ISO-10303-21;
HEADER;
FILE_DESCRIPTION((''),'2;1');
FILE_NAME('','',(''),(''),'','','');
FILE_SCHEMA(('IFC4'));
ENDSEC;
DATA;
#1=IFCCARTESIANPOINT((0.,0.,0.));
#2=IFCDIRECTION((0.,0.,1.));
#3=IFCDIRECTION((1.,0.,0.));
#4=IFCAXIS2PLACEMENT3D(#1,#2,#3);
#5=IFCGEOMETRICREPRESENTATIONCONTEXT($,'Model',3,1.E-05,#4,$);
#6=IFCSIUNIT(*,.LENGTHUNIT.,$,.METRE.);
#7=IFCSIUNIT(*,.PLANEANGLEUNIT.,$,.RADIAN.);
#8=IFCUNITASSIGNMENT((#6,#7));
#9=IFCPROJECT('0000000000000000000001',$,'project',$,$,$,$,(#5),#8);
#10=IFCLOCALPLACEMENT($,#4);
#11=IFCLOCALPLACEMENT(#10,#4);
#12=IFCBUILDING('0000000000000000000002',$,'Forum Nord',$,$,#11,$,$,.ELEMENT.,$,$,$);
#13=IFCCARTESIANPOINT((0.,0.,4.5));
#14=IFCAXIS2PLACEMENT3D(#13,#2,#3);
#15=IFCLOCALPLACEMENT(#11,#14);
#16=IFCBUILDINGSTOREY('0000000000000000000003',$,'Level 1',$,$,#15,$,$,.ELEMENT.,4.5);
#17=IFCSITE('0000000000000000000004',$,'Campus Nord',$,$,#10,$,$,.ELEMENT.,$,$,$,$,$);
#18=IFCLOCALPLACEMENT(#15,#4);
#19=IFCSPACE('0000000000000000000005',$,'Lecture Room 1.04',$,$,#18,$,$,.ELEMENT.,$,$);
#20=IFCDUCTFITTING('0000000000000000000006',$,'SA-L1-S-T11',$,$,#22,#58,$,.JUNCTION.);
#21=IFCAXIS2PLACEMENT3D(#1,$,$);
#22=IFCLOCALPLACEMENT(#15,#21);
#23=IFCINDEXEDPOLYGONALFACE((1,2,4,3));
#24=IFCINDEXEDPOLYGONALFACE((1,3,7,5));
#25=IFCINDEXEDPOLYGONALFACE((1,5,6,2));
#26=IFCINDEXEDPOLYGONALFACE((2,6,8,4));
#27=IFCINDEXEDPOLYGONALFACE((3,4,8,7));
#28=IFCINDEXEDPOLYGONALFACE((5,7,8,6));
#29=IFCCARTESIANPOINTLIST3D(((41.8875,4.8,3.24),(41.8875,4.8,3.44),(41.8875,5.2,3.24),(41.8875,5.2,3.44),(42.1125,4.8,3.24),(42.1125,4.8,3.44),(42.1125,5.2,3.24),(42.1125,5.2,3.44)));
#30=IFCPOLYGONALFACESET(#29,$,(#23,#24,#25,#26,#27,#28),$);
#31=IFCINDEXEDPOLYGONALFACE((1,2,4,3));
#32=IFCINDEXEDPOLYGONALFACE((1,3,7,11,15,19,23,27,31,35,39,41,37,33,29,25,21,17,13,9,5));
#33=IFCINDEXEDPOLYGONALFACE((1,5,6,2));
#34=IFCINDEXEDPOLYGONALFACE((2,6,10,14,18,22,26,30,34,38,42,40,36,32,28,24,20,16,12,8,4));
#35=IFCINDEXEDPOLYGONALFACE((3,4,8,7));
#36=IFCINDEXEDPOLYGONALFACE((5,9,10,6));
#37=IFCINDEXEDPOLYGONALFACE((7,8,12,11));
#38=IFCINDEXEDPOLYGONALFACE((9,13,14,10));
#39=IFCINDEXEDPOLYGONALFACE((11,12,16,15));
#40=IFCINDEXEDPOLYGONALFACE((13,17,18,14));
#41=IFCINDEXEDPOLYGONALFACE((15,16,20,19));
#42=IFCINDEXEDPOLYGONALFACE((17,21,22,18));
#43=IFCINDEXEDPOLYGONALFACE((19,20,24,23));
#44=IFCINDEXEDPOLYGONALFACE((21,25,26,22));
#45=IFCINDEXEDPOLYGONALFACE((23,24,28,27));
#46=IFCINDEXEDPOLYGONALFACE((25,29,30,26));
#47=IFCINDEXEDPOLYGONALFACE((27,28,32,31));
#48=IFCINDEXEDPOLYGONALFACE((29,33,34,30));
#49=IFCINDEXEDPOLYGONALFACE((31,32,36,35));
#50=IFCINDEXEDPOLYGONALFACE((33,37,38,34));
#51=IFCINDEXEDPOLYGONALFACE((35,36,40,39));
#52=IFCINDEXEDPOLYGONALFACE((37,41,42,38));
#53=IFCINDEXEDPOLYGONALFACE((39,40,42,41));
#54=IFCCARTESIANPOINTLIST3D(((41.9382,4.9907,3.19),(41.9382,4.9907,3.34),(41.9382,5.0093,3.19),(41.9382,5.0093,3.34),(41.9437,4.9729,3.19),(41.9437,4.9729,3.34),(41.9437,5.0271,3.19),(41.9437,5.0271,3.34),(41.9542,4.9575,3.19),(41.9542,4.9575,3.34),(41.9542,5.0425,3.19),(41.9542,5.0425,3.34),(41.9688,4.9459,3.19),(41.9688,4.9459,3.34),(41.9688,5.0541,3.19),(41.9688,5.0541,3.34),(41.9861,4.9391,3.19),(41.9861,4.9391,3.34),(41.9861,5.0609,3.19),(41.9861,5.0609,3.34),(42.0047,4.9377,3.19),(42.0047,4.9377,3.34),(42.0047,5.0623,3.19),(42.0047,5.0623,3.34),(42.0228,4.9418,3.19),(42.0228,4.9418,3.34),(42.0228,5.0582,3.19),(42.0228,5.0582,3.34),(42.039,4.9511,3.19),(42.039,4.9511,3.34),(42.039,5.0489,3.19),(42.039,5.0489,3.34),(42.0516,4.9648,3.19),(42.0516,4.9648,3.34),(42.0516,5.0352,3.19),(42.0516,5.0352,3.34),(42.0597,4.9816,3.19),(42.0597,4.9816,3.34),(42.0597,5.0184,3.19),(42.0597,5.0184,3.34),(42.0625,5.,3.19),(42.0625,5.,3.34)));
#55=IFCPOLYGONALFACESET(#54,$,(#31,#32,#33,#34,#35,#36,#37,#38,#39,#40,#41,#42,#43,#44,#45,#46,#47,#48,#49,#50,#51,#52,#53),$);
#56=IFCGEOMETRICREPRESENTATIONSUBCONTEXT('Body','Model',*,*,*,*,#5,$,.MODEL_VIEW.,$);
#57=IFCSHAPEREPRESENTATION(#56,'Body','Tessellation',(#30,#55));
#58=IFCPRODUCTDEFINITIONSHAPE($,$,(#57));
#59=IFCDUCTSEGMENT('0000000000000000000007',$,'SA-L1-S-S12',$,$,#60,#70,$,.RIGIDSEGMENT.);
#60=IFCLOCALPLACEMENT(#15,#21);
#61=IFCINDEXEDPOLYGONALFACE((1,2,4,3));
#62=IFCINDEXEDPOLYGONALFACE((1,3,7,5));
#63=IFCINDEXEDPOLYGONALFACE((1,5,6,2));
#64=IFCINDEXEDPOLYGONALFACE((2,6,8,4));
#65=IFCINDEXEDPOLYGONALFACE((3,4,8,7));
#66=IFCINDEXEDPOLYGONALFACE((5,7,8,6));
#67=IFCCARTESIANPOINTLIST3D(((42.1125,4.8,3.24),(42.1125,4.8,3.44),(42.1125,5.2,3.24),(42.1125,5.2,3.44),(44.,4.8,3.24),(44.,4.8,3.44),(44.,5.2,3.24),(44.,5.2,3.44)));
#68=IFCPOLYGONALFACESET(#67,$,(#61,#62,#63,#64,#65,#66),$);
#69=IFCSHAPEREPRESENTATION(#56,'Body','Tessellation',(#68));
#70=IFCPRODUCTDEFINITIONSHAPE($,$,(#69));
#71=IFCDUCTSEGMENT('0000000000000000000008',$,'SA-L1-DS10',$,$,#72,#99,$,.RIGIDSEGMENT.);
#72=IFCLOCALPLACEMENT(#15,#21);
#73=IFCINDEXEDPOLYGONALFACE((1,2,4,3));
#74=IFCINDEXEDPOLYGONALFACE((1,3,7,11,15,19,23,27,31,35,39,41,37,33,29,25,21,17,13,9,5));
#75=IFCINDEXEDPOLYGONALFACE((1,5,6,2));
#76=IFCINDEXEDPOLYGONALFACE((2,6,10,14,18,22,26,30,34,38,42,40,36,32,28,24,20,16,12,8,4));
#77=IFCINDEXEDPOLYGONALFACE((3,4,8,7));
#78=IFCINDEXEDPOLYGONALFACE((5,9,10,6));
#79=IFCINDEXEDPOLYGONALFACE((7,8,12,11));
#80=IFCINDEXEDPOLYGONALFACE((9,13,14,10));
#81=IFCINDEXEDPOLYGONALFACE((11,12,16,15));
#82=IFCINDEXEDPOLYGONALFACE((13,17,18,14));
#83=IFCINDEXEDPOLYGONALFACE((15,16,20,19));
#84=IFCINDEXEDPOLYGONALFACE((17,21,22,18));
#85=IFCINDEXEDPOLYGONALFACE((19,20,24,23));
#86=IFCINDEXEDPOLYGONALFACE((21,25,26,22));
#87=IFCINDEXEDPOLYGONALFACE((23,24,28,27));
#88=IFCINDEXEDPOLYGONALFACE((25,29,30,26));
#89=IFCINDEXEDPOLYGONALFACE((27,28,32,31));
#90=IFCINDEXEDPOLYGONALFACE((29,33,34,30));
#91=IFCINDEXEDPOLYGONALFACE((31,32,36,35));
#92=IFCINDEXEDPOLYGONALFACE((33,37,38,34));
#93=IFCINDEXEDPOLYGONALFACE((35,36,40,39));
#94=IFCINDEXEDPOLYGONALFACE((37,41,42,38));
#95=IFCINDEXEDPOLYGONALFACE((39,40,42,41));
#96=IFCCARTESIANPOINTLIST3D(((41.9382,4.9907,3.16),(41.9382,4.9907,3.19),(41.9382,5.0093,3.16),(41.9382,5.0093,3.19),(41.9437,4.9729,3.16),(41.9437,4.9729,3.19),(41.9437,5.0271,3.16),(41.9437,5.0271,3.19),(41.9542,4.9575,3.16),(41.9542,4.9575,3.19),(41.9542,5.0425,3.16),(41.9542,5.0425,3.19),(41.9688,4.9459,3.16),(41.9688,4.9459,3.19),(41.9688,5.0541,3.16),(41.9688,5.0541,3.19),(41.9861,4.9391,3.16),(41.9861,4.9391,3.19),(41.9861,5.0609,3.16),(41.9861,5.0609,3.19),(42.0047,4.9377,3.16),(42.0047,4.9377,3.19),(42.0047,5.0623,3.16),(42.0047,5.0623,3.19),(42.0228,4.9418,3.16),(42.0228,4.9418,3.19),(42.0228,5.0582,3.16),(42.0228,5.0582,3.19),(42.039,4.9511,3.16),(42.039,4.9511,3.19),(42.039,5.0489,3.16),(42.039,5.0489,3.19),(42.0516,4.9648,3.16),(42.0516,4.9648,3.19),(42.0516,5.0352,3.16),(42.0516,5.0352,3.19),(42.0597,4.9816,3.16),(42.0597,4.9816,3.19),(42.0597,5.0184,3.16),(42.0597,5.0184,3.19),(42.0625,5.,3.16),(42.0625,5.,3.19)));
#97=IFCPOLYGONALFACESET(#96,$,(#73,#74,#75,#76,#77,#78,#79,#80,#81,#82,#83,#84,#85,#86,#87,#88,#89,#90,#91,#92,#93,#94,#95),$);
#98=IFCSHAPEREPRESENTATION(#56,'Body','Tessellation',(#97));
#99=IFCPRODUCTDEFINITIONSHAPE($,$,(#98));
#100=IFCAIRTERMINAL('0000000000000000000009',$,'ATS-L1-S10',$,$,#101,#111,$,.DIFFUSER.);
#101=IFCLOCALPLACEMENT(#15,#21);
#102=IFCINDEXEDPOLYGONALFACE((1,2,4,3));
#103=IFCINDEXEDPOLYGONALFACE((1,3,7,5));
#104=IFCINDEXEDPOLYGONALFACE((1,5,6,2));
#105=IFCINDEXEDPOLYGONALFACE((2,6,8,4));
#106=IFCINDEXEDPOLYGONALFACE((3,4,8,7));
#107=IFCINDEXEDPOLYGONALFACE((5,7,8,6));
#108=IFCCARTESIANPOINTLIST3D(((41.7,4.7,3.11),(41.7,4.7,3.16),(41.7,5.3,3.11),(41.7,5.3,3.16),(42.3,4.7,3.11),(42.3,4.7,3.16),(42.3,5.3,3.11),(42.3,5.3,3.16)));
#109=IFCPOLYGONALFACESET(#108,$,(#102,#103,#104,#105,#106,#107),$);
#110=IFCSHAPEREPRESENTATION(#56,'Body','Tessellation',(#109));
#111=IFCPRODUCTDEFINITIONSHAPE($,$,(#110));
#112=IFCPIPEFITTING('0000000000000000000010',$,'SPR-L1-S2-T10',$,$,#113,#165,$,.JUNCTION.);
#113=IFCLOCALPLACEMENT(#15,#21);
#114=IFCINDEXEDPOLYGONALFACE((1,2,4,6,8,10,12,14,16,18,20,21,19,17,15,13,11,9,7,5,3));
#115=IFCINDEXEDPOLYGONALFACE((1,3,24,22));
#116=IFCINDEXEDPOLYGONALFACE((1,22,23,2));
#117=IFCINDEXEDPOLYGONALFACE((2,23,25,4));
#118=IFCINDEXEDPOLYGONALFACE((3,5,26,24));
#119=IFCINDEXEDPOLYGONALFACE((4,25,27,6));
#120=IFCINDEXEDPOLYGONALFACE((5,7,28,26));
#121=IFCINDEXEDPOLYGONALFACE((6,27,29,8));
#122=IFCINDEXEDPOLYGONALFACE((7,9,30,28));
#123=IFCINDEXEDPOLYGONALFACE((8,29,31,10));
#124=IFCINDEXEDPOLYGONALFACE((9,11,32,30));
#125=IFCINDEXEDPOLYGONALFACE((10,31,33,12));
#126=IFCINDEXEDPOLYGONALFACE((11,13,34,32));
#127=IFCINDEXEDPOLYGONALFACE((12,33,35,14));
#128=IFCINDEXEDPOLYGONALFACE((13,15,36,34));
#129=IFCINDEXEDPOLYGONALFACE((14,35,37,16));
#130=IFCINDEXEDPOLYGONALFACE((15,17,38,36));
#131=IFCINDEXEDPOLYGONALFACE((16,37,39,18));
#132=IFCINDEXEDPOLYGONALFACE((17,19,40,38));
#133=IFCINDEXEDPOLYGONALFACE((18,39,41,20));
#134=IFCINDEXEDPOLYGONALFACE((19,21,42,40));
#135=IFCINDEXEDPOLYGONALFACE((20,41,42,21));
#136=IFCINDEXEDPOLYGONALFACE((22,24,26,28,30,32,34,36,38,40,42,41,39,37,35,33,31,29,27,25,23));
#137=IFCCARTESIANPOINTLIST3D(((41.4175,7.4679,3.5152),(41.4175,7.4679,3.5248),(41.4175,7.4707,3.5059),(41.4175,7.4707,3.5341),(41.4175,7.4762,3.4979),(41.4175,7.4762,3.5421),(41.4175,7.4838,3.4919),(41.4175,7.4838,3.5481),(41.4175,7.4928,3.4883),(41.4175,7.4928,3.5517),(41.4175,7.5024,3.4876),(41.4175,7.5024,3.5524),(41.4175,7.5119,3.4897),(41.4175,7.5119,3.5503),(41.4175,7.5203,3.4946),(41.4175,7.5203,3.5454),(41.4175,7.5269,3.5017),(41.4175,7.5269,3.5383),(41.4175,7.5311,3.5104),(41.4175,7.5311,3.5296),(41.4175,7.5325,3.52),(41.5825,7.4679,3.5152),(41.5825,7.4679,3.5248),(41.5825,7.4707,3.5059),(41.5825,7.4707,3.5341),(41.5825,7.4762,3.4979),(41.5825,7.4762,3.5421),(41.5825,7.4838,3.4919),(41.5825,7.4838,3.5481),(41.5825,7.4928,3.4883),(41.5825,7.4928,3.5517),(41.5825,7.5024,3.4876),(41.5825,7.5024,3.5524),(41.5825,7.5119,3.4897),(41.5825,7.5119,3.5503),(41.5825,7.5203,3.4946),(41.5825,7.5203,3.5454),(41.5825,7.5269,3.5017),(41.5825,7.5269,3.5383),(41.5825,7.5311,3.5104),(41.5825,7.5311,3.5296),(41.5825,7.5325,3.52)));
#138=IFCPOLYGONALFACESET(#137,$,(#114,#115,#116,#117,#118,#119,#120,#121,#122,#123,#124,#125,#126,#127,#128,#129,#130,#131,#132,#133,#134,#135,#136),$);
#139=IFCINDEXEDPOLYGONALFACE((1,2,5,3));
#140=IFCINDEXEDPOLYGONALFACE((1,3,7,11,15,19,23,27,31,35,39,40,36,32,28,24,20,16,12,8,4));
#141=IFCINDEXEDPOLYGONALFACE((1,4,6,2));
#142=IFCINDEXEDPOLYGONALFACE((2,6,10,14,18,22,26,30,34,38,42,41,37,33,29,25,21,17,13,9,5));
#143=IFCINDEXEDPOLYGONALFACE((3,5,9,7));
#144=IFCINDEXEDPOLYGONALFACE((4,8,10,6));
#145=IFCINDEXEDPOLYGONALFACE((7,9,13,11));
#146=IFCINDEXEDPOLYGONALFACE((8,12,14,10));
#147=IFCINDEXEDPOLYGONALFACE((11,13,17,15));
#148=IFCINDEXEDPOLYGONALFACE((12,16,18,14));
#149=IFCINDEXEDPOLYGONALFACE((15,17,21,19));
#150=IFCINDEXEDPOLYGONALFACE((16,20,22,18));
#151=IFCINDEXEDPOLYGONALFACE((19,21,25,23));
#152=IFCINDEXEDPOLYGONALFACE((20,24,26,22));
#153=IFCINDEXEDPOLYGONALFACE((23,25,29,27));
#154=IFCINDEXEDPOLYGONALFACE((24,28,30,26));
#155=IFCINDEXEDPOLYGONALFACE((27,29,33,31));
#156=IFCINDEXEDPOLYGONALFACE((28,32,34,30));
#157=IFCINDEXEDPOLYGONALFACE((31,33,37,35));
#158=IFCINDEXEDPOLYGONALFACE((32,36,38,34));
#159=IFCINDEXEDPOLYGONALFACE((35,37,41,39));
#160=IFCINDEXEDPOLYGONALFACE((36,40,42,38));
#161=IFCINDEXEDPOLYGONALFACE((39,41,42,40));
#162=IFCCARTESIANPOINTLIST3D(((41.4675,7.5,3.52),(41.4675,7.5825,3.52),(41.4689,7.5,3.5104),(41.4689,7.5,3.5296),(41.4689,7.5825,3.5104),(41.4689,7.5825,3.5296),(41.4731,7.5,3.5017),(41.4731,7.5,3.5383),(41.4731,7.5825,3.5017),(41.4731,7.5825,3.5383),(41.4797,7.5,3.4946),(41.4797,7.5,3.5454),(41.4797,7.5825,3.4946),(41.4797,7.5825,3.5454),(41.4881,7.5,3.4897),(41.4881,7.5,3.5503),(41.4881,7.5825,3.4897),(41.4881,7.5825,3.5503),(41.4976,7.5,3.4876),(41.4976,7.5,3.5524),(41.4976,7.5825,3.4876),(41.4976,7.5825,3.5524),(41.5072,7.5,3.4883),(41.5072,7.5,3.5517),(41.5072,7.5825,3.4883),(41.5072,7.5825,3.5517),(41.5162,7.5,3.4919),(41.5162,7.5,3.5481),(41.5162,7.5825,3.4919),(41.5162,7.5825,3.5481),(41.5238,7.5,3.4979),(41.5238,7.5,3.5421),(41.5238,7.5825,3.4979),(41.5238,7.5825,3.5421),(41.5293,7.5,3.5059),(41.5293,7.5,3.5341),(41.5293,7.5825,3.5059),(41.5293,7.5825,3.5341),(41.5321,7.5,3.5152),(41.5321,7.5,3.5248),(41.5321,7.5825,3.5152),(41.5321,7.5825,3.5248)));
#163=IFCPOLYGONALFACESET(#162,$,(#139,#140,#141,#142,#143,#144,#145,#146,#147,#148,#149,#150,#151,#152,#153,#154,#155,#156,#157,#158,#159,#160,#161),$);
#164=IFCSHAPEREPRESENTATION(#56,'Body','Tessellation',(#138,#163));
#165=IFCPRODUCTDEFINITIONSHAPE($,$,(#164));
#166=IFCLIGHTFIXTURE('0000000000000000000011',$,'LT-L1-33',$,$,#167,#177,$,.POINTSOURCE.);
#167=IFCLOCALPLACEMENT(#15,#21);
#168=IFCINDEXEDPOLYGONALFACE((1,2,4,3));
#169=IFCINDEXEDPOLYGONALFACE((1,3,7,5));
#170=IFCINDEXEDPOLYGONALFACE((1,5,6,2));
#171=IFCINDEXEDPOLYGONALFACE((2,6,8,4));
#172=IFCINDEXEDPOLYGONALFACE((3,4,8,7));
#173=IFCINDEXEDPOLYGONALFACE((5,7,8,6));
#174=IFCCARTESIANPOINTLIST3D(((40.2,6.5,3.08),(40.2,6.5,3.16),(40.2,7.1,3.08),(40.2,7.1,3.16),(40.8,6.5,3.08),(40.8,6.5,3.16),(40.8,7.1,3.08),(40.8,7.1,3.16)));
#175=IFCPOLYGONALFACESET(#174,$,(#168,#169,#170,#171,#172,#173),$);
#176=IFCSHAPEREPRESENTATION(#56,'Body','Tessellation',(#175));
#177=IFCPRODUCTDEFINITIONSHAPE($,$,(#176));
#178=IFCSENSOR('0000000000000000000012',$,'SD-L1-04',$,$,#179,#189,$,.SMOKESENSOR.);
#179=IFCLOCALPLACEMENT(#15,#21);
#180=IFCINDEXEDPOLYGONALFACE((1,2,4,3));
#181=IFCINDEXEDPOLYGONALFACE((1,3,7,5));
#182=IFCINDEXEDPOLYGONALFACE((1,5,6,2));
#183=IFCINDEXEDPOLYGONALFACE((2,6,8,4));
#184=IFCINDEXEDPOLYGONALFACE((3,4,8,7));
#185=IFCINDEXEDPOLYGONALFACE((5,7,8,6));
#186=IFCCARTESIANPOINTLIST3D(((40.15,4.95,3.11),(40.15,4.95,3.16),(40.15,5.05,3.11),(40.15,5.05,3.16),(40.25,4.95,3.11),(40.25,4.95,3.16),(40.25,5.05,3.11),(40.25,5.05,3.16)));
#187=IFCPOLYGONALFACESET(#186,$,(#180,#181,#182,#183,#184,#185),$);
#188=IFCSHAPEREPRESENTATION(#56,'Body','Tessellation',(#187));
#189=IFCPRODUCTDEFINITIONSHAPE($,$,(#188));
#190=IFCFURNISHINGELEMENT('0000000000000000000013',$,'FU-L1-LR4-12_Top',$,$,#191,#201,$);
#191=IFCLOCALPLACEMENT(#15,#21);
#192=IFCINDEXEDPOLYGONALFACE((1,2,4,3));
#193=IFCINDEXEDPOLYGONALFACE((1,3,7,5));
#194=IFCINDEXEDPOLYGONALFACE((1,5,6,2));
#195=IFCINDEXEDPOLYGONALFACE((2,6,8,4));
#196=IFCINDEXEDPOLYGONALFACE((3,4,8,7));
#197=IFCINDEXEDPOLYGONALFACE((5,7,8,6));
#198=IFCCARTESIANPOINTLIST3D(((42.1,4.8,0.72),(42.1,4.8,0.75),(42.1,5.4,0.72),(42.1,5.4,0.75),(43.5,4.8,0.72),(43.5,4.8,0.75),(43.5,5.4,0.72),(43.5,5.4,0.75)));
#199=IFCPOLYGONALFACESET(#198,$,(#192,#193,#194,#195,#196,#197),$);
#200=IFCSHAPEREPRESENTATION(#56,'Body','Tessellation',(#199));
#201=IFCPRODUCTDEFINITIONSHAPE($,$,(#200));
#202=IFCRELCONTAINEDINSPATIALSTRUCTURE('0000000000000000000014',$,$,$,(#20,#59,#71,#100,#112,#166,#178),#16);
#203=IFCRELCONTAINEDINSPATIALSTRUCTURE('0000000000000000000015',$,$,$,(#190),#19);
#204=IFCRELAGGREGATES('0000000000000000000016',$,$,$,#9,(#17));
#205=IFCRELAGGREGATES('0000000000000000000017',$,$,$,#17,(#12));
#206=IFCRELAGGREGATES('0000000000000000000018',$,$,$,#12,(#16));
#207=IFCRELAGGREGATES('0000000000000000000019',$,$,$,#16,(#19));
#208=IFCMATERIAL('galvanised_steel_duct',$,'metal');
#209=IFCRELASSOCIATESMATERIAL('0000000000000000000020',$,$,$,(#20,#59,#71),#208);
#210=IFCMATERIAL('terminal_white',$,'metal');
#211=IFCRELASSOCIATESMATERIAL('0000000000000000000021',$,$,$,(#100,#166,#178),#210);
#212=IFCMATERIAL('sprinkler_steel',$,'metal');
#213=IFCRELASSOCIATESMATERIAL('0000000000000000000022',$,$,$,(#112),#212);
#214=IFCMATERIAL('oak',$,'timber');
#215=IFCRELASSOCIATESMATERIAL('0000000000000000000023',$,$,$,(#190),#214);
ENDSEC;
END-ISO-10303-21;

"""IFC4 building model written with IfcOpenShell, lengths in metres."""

from ifc_helpers import new_model, si_unit, frame, frame_2d, origin_with_axes, origin_2d_with_axis, place, context, subcontext, project, spatial, rectangle, circle, extrude, material, element, save


model = new_model("IFC4")

# Units and contexts
model_context = context("Model", 3, precision=1e-05, world=origin_with_axes())
body_context = subcontext(model_context, "Body", "Model", "MODEL_VIEW")
ifc_project = project(units=[si_unit("LENGTHUNIT", "METRE"), si_unit("PLANEANGLEUNIT", "RADIAN")], contexts=[model_context])

# Site, building, storey
site_placement = place(None, origin_with_axes())
site = spatial("IfcSite", under=ifc_project, at=site_placement, Name="Campus Nord", CompositionType="ELEMENT")
building_placement = place(site_placement, origin_with_axes())
building = spatial("IfcBuilding", under=site, at=building_placement, Name="Forum Nord", CompositionType="ELEMENT")
storey_placement = place(building_placement, frame((0.0, 0.0, 4.5), z_axis=(0.0, 0.0, 1.0), x_axis=(1.0, 0.0, 0.0)))
storey = spatial("IfcBuildingStorey", under=building, at=storey_placement, Name="Level 1", CompositionType="ELEMENT", Elevation=4.5)

# Duct fitting
ifc_material_1 = material(Name="galvanised_steel_duct", Category="metal")
duct_fitting_placement = place(storey_placement, frame((41.8875, 5.0, 3.34), z_axis=(1.0, 0.0, 0.0), x_axis=(0.0, 1.0, 0.0)))
element("IfcDuctFitting", 1, at=duct_fitting_placement, inside=storey, material=ifc_material_1, Name="SA-L1-S-T11", PredefinedType="JUNCTION", context=body_context, shape_type="SweptSolid", body=[
    extrude(rectangle(XDim=0.4, YDim=0.2, at=origin_2d_with_axis()), origin_with_axes(), (0.0, 0.0, 1.0), 0.225),
    extrude(circle(Radius=0.0625, at=origin_2d_with_axis()), frame((0.0, 0.0, 0.1125), z_axis=(0.0, -1.0, 0.0), x_axis=(0.0, 0.0, 1.0)), (0.0, 0.0, 1.0), 0.15),
])

# Duct segments
duct_segment_1_placement = place(storey_placement, frame((42.1125, 5.0, 3.34), z_axis=(1.0, 0.0, 0.0), x_axis=(0.0, 1.0, 0.0)))
element("IfcDuctSegment", 2, at=duct_segment_1_placement, inside=storey, material=ifc_material_1, Name="SA-L1-S-S12", PredefinedType="RIGIDSEGMENT", context=body_context, shape_type="SweptSolid", body=[
    extrude(rectangle(XDim=0.4, YDim=0.2, at=origin_2d_with_axis()), origin_with_axes(), (0.0, 0.0, 1.0), 1.8875),
])
duct_segment_2_placement = place(storey_placement, frame((42.0, 5.0, 3.19), z_axis=(0.0, 0.0, -1.0), x_axis=(1.0, 0.0, 0.0)))
element("IfcDuctSegment", 3, at=duct_segment_2_placement, inside=storey, material=ifc_material_1, Name="SA-L1-DS10", PredefinedType="RIGIDSEGMENT", context=body_context, shape_type="SweptSolid", body=[
    extrude(circle(Radius=0.0625, at=origin_2d_with_axis()), origin_with_axes(), (0.0, 0.0, 1.0), 0.03),
])

# Air terminal
ifc_material_2 = material(Name="terminal_white", Category="metal")
air_terminal_placement = place(storey_placement, frame((42.0, 5.0, 3.11), z_axis=(0.0, 0.0, 1.0), x_axis=(1.0, 0.0, 0.0)))
element("IfcAirTerminal", 4, at=air_terminal_placement, inside=storey, material=ifc_material_2, Name="ATS-L1-S10", PredefinedType="DIFFUSER", context=body_context, shape_type="SweptSolid", body=[
    extrude(rectangle(XDim=0.6, YDim=0.6, at=origin_2d_with_axis()), origin_with_axes(), (0.0, 0.0, 1.0), 0.05),
])

# Pipe fitting
ifc_material_3 = material(Name="sprinkler_steel", Category="metal")
pipe_fitting_placement = place(storey_placement, frame((41.4175, 7.5, 3.52), z_axis=(1.0, 0.0, 0.0), x_axis=(0.0, 1.0, 0.0)))
element("IfcPipeFitting", 5, at=pipe_fitting_placement, inside=storey, material=ifc_material_3, Name="SPR-L1-S2-T10", PredefinedType="JUNCTION", context=body_context, shape_type="SweptSolid", body=[
    extrude(circle(Radius=0.0325, at=origin_2d_with_axis()), origin_with_axes(), (0.0, 0.0, 1.0), 0.165),
    extrude(circle(Radius=0.0325, at=origin_2d_with_axis()), frame((0.0, 0.0, 0.0825), z_axis=(1.0, 0.0, 0.0), x_axis=(0.0, 0.0, -1.0)), (0.0, 0.0, 1.0), 0.0825),
])

# Light fixture
light_fixture_placement = place(storey_placement, frame((40.5, 6.8, 3.08), z_axis=(0.0, 0.0, 1.0), x_axis=(1.0, 0.0, 0.0)))
element("IfcLightFixture", 6, at=light_fixture_placement, inside=storey, material=ifc_material_2, Name="LT-L1-33", PredefinedType="POINTSOURCE", context=body_context, shape_type="SweptSolid", body=[
    extrude(rectangle(XDim=0.6, YDim=0.6, at=origin_2d_with_axis()), origin_with_axes(), (0.0, 0.0, 1.0), 0.08),
])

# Sensor
sensor_placement = place(storey_placement, frame((40.2, 5.0, 3.11), z_axis=(0.0, 0.0, 1.0), x_axis=(1.0, 0.0, 0.0)))
element("IfcSensor", 7, at=sensor_placement, inside=storey, material=ifc_material_2, Name="SD-L1-04", PredefinedType="SMOKESENSOR", context=body_context, shape_type="SweptSolid", body=[
    extrude(rectangle(XDim=0.1, YDim=0.1, at=origin_2d_with_axis()), origin_with_axes(), (0.0, 0.0, 1.0), 0.05),
])

# Shared definitions
space_placement = place(storey_placement, origin_with_axes())
space = spatial("IfcSpace", under=storey, at=space_placement, Name="Lecture Room 1.04", CompositionType="ELEMENT")

# Furnishing element
ifc_material_4 = material(Name="oak", Category="timber")
furnishing_1_placement = place(storey_placement, frame((42.1, 4.8, 0.0), z_axis=(0.0, 0.0, 1.0), x_axis=(1.0, 0.0, 0.0)))
element("IfcFurnishingElement", 8, at=furnishing_1_placement, inside=space, material=ifc_material_4, Name="FU-L1-LR4-12_Top", context=body_context, shape_type="SweptSolid", body=[
    extrude(rectangle(XDim=1.4, YDim=0.6, at=frame_2d((0.7, 0.3), x_axis=(1.0, 0.0))), frame((0.0, 0.0, 0.72), z_axis=(0.0, 0.0, 1.0), x_axis=(1.0, 0.0, 0.0)), (0.0, 0.0, 1.0), 0.03),
])

save(model, "model.ifc")
